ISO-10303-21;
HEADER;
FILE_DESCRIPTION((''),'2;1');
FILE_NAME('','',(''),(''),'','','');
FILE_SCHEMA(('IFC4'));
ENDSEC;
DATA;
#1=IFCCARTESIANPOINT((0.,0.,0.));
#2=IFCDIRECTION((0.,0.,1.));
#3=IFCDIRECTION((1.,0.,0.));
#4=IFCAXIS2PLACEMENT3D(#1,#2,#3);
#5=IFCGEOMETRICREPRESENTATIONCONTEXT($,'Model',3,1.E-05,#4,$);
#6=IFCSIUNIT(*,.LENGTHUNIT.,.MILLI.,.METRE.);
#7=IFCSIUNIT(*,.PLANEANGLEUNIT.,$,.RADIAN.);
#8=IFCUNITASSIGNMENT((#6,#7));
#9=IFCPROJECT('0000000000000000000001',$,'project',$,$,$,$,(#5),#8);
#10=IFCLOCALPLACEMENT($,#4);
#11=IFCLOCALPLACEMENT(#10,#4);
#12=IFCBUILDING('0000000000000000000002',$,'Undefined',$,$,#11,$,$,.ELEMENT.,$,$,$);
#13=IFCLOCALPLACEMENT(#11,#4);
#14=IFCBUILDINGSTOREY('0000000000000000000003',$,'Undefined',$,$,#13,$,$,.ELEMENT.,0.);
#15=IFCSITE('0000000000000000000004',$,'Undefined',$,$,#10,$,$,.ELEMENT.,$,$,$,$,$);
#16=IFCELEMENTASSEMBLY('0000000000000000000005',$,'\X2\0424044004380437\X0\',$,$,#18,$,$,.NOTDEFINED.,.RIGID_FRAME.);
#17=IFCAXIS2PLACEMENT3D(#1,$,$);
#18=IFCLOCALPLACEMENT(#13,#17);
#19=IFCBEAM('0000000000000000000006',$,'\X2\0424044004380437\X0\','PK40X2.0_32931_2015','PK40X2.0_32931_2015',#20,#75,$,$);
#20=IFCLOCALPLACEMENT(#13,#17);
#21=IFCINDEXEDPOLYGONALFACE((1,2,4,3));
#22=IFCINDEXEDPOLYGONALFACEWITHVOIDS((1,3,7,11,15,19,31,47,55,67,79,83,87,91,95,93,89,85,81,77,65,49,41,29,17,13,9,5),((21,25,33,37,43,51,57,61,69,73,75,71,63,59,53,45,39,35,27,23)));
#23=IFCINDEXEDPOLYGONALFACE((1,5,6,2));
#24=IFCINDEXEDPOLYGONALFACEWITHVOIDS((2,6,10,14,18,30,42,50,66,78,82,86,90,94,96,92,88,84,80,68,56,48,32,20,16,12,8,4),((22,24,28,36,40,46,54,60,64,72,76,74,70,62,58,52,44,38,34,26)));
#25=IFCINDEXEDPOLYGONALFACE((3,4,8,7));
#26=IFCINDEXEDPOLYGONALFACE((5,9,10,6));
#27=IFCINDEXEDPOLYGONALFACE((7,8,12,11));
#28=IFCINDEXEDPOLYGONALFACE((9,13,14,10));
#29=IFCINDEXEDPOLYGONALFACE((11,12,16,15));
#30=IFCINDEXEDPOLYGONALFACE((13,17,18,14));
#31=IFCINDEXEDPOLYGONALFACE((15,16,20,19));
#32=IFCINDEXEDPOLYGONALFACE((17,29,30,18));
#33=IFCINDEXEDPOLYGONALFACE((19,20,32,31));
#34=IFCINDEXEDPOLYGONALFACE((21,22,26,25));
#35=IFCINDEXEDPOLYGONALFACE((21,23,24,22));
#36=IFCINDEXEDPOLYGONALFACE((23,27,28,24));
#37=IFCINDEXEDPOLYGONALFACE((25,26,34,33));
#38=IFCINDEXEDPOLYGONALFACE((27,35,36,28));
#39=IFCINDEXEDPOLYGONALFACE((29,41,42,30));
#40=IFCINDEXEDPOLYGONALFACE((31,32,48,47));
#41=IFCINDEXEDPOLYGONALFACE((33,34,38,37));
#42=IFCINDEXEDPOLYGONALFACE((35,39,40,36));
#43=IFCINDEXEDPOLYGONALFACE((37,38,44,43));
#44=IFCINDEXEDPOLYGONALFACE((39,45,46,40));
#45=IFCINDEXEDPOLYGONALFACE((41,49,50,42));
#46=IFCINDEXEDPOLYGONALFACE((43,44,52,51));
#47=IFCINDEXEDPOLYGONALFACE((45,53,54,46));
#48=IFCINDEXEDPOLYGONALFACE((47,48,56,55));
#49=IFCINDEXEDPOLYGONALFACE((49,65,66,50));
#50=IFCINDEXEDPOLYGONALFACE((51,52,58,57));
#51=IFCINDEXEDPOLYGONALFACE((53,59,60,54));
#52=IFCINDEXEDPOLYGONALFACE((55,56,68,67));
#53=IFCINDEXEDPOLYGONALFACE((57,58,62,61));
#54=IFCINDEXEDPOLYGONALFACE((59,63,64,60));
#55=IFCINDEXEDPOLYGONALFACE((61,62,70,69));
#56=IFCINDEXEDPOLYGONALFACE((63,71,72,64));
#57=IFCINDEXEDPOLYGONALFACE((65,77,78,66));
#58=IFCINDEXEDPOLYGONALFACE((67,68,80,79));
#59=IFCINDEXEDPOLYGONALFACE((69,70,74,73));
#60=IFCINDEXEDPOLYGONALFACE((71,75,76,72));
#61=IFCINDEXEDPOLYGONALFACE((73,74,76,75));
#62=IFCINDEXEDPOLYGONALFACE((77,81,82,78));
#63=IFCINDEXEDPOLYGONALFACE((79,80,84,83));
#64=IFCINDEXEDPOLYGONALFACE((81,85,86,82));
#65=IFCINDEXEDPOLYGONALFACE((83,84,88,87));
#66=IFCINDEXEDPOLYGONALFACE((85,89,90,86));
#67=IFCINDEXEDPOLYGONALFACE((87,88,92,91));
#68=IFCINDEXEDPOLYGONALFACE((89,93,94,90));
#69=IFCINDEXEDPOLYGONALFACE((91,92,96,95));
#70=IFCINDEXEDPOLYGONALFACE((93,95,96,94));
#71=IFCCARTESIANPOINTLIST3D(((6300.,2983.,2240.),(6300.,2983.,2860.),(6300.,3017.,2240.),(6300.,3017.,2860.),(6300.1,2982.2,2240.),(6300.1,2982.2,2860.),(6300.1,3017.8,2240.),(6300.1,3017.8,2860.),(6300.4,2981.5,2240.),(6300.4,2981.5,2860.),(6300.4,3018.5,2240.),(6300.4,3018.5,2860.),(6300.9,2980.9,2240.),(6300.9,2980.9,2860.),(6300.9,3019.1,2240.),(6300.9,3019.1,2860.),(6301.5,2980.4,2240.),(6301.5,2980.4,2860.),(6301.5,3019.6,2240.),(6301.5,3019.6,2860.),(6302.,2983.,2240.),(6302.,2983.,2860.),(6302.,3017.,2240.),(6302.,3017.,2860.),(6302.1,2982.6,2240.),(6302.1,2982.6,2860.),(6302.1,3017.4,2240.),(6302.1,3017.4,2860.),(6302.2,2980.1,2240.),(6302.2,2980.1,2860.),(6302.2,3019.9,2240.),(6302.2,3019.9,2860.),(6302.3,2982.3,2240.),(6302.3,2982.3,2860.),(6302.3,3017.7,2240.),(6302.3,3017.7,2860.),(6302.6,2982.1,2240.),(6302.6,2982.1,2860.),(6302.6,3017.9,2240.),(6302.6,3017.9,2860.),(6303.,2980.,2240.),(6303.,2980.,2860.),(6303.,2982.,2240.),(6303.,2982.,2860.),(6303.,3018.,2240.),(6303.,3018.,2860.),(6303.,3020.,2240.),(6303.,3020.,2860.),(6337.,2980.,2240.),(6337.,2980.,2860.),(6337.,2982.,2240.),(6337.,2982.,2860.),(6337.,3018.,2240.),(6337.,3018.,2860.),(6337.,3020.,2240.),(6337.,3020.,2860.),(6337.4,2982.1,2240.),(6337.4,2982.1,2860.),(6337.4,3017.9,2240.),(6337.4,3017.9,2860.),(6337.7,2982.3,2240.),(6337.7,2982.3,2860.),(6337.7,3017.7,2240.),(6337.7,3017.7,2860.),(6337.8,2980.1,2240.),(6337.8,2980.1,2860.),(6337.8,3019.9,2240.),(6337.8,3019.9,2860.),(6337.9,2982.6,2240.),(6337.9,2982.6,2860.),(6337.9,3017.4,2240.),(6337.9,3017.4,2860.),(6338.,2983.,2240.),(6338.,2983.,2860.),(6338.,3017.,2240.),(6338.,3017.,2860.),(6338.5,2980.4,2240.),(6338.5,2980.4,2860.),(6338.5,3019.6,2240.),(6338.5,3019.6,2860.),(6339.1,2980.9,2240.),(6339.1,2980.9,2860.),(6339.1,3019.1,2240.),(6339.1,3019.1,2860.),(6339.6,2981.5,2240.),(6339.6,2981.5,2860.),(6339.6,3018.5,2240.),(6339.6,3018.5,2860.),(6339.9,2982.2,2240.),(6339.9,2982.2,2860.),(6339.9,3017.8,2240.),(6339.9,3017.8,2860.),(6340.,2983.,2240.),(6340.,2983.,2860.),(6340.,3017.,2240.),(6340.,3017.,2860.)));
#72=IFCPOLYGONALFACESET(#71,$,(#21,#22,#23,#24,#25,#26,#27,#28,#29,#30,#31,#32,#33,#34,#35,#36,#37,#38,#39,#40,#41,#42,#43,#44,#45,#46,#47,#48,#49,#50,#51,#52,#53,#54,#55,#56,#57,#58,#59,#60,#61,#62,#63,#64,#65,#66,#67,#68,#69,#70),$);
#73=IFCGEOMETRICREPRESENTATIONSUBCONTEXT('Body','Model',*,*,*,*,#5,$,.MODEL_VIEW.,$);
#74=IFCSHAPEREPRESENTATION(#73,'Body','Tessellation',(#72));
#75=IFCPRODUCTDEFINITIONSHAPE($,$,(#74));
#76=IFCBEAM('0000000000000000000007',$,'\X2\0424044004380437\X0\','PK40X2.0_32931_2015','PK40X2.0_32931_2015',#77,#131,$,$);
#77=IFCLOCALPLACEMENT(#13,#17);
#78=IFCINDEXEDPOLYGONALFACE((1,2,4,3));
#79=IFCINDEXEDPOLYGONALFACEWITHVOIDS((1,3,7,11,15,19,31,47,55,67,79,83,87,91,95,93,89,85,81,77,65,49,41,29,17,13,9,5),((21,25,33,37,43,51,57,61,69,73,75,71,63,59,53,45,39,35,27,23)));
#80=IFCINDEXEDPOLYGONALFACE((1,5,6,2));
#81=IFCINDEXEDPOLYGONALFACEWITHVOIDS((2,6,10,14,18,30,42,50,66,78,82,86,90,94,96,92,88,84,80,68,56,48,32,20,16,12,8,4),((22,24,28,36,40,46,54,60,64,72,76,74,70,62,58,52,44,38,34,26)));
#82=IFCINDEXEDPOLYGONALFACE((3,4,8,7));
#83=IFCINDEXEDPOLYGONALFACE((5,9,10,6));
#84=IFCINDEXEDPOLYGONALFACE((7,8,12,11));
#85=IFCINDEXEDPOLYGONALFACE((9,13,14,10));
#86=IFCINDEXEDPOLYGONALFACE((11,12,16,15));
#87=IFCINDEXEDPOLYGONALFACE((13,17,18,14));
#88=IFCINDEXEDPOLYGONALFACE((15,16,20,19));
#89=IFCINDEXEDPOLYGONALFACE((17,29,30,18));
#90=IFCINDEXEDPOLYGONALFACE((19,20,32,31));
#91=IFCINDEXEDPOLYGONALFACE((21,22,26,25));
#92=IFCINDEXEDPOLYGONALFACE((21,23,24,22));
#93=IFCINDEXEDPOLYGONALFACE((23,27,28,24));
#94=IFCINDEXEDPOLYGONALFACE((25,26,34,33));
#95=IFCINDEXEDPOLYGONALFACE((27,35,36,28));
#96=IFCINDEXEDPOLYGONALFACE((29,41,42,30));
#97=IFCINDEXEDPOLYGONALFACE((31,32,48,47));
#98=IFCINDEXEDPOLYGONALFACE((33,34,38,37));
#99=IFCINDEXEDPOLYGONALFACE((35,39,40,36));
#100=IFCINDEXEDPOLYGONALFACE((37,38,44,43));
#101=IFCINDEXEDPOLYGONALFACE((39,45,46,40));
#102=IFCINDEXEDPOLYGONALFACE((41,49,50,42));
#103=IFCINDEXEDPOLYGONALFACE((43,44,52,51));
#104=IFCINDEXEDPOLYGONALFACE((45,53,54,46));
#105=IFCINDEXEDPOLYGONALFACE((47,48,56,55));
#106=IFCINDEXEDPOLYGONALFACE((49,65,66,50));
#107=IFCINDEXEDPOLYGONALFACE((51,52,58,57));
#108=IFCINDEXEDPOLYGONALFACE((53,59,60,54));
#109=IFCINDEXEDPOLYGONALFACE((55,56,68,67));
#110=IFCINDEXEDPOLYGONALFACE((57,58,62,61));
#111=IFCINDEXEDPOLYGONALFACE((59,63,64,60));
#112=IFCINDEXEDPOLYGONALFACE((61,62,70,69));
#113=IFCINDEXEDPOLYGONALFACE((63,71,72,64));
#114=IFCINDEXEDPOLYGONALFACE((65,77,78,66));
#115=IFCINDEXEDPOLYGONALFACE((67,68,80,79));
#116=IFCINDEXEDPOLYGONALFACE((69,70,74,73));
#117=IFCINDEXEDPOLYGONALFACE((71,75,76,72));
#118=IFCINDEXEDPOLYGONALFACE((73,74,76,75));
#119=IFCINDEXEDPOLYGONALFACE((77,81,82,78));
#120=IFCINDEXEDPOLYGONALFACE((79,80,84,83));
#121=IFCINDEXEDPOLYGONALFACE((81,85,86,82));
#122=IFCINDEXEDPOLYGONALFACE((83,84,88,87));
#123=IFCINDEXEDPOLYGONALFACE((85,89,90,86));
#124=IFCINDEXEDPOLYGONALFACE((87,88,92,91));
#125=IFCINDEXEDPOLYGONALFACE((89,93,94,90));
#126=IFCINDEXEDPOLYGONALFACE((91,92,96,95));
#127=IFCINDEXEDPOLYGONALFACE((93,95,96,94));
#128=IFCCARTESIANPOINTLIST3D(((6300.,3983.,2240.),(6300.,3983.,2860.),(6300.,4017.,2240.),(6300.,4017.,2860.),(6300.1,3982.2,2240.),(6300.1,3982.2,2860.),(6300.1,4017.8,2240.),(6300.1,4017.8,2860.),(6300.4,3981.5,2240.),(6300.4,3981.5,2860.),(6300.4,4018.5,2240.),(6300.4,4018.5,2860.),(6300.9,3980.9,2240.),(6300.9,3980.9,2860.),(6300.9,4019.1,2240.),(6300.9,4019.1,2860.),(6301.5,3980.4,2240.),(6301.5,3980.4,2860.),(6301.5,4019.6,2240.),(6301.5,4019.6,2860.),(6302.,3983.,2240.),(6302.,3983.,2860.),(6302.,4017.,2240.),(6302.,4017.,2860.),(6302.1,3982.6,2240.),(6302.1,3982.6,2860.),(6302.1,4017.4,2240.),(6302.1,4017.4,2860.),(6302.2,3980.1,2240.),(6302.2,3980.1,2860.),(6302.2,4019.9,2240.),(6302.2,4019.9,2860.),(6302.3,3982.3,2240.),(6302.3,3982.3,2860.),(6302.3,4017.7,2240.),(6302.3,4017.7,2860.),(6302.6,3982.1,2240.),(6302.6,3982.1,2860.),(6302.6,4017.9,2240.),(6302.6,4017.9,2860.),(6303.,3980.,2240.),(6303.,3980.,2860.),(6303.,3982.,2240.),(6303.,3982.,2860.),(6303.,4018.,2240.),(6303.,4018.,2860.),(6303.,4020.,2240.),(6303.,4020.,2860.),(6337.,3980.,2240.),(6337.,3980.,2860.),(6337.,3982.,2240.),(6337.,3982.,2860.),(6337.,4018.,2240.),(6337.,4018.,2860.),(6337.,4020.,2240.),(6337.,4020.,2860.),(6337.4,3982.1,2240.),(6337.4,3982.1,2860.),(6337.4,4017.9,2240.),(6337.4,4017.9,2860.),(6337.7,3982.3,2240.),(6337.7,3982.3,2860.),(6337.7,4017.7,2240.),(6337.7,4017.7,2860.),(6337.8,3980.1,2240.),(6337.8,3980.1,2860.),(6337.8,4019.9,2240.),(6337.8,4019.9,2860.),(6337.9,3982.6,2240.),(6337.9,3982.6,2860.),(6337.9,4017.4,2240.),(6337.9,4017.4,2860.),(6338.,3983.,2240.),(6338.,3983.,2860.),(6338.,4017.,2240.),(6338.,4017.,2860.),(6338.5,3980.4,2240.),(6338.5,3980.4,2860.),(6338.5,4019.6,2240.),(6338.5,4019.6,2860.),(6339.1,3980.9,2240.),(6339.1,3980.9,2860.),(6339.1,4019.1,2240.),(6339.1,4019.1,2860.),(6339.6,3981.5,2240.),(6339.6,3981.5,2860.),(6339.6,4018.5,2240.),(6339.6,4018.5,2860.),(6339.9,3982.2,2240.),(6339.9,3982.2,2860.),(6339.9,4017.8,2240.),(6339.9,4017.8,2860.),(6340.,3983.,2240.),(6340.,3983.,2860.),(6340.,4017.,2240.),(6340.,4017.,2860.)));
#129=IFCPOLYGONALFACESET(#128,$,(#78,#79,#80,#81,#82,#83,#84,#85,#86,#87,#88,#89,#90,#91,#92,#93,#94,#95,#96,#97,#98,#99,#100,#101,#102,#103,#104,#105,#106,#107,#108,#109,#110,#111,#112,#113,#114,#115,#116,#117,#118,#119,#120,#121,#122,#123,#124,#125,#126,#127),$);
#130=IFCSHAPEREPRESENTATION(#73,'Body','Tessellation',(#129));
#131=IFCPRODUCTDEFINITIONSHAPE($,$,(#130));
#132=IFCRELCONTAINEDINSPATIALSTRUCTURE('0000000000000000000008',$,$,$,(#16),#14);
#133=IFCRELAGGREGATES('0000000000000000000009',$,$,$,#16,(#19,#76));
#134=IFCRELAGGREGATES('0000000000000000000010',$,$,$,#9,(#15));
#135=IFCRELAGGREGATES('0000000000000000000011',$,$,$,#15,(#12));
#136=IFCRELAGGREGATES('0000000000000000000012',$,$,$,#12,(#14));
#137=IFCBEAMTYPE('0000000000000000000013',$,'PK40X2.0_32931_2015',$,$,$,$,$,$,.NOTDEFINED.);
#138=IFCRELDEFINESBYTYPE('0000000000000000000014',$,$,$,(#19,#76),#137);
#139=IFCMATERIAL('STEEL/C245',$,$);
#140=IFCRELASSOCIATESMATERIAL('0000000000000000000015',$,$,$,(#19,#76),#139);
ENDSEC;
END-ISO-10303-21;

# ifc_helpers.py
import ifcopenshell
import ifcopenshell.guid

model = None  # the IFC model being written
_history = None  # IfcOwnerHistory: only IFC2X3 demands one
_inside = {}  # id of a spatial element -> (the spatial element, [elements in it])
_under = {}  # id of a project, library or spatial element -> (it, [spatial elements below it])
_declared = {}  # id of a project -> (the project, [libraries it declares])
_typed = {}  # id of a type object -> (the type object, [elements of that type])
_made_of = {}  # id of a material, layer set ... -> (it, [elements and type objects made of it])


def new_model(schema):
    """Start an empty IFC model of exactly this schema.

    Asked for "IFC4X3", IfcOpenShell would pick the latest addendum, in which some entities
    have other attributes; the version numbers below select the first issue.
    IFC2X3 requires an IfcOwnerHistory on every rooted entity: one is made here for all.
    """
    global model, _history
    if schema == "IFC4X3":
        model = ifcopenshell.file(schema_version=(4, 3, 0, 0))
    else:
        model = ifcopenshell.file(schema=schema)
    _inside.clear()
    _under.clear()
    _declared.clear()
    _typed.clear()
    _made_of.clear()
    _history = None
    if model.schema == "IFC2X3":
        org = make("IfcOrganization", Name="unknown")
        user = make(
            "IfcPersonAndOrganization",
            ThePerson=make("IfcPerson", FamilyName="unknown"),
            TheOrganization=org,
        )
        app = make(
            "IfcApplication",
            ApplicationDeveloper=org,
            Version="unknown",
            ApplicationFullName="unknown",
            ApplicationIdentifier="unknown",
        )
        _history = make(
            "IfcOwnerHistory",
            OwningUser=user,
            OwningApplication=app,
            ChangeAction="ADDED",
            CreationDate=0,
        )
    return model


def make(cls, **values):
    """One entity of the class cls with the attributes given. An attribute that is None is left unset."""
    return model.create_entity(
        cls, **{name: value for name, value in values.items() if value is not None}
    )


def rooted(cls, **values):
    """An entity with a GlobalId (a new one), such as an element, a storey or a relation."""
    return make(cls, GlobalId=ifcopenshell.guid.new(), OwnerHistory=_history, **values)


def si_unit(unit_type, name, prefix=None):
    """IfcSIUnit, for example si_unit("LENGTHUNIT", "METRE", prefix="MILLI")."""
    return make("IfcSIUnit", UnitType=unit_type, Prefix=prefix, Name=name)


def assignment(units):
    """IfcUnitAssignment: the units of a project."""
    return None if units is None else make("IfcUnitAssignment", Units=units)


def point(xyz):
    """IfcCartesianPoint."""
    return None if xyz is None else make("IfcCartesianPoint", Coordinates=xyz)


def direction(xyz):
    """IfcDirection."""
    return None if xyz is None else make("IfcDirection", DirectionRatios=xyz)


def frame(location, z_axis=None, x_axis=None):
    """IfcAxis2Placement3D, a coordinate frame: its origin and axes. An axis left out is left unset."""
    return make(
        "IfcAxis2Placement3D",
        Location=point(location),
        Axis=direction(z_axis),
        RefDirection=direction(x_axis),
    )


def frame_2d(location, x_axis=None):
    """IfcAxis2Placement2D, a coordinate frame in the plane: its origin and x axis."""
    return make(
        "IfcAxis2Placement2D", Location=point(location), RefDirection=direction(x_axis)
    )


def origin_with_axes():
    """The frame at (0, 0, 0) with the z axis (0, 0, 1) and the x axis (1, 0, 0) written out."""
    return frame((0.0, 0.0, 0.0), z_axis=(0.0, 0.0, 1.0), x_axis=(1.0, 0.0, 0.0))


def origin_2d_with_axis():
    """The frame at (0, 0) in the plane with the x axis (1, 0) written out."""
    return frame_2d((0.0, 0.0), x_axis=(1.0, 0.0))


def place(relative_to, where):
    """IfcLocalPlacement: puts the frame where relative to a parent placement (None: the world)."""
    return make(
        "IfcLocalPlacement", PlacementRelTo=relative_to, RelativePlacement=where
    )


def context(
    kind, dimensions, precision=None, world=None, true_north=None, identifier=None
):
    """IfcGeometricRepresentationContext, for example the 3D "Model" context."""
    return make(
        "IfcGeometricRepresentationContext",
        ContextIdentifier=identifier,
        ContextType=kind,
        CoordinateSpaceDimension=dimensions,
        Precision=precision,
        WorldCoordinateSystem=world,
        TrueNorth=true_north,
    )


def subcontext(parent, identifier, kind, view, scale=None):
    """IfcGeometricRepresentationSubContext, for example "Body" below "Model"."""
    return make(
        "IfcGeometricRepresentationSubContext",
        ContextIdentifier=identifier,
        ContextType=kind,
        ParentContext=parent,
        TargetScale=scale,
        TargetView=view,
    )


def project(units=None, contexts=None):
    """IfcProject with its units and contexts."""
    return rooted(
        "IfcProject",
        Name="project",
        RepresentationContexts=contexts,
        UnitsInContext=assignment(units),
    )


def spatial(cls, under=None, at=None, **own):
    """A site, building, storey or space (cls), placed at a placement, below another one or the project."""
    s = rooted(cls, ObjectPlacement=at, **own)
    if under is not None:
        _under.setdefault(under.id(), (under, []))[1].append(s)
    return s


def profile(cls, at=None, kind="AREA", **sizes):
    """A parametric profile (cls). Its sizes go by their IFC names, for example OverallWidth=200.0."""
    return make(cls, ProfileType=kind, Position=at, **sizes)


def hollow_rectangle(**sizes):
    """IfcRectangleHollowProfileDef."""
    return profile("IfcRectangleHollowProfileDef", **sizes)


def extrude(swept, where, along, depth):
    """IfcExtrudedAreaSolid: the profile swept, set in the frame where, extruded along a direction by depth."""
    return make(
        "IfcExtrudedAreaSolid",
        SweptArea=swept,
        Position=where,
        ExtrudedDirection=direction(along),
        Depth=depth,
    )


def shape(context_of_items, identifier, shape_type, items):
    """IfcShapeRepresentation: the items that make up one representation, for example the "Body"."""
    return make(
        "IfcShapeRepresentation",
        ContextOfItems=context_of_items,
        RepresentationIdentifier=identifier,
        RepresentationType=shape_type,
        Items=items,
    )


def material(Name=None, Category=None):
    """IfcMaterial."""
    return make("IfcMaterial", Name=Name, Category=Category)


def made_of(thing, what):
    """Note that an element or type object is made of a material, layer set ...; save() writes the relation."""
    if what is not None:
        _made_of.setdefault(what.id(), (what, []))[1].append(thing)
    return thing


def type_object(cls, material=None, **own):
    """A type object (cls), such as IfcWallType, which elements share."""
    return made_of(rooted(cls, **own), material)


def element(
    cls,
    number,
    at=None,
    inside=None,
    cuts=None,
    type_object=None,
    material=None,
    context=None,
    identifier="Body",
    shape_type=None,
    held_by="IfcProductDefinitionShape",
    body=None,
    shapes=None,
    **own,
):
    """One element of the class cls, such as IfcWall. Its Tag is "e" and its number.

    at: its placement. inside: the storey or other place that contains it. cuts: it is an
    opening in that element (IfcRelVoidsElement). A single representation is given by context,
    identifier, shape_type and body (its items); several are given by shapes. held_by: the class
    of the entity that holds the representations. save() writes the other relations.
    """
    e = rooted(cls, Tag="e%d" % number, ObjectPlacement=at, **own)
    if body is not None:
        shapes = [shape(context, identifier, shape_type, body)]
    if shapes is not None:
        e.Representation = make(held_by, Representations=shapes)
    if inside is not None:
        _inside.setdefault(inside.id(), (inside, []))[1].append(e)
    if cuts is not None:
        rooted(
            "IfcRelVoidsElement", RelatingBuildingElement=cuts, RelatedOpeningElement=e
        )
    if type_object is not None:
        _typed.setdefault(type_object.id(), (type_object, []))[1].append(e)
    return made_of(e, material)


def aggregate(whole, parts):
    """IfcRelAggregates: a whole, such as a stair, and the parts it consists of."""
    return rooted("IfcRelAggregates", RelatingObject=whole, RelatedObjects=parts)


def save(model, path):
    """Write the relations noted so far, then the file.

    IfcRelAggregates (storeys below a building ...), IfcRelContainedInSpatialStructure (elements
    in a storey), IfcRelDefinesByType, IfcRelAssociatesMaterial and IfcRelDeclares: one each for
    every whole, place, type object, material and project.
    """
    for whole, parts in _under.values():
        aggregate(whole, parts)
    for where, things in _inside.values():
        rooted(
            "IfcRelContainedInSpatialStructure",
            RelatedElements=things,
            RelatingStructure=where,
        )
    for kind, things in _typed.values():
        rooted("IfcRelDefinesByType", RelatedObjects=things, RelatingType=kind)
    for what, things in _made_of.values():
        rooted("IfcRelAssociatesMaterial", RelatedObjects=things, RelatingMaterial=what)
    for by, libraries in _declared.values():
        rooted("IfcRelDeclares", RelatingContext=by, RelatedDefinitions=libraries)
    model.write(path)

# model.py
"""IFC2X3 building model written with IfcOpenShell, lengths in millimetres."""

from ifc_helpers import new_model, si_unit, frame, origin_with_axes, origin_2d_with_axis, place, context, subcontext, project, spatial, hollow_rectangle, extrude, material, type_object, element, aggregate, save


model = new_model("IFC2X3")

# Units and contexts
model_context = context("Model", 3, precision=1e-05, world=origin_with_axes())
body_context = subcontext(model_context, "Body", "Model", "MODEL_VIEW")
ifc_project = project(units=[si_unit("LENGTHUNIT", "METRE", prefix="MILLI"), si_unit("PLANEANGLEUNIT", "RADIAN")], contexts=[model_context])

# Site, building, storey
site_placement = place(None, origin_with_axes())
site = spatial("IfcSite", under=ifc_project, at=site_placement, Name="Undefined", CompositionType="ELEMENT")
building_placement = place(site_placement, origin_with_axes())
building = spatial("IfcBuilding", under=site, at=building_placement, Name="Undefined", CompositionType="ELEMENT")
storey_placement = place(building_placement, origin_with_axes())
storey = spatial("IfcBuildingStorey", under=building, at=storey_placement, Name="Undefined", CompositionType="ELEMENT", Elevation=0.0)

# Shared definitions
ifc_material_1 = material(Name="STEEL/C245")

# Element assembly
assembly_1_placement = place(storey_placement, origin_with_axes())
assembly_1 = element("IfcElementAssembly", 1, at=assembly_1_placement, inside=storey, Name="Фриз", AssemblyPlace="NOTDEFINED", PredefinedType="RIGID_FRAME")

# Shared definitions
beam_type_1 = type_object("IfcBeamType", Name="PK40X2.0_32931_2015", PredefinedType="NOTDEFINED")

# Beams
beam_1_placement = place(assembly_1_placement, frame((6320.0, 3000.0, 2860.0), z_axis=(-1.0, 0.0, 0.0), x_axis=(0.0, 0.0, -1.0)))
beam_1 = element("IfcBeam", 2, at=beam_1_placement, type_object=beam_type_1, material=ifc_material_1, Name="Фриз", Description="PK40X2.0_32931_2015", ObjectType="PK40X2.0_32931_2015", context=body_context, shape_type="SweptSolid", body=[
    extrude(hollow_rectangle(XDim=40.0, YDim=40.0, WallThickness=2.0, InnerFilletRadius=1.0, OuterFilletRadius=3.0, at=origin_2d_with_axis()), frame((620.0, 0.0, 0.0), z_axis=(-1.0, 0.0, 0.0), x_axis=(0.0, -1.0, 0.0)), (0.0, 0.0, 1.0), 620.0),
])
beam_2_placement = place(assembly_1_placement, frame((6320.0, 4000.0, 2860.0), z_axis=(-1.0, 0.0, 0.0), x_axis=(0.0, 0.0, -1.0)))
beam_2 = element("IfcBeam", 3, at=beam_2_placement, type_object=beam_type_1, material=ifc_material_1, Name="Фриз", Description="PK40X2.0_32931_2015", ObjectType="PK40X2.0_32931_2015", context=body_context, shape_type="SweptSolid", body=[
    extrude(hollow_rectangle(XDim=40.0, YDim=40.0, WallThickness=2.0, InnerFilletRadius=1.0, OuterFilletRadius=3.0, at=origin_2d_with_axis()), frame((620.0, 0.0, 0.0), z_axis=(-1.0, 0.0, 0.0), x_axis=(0.0, -1.0, 0.0)), (0.0, 0.0, 1.0), 620.0),
])
aggregate(assembly_1, [beam_1, beam_2])

save(model, "model.ifc")
